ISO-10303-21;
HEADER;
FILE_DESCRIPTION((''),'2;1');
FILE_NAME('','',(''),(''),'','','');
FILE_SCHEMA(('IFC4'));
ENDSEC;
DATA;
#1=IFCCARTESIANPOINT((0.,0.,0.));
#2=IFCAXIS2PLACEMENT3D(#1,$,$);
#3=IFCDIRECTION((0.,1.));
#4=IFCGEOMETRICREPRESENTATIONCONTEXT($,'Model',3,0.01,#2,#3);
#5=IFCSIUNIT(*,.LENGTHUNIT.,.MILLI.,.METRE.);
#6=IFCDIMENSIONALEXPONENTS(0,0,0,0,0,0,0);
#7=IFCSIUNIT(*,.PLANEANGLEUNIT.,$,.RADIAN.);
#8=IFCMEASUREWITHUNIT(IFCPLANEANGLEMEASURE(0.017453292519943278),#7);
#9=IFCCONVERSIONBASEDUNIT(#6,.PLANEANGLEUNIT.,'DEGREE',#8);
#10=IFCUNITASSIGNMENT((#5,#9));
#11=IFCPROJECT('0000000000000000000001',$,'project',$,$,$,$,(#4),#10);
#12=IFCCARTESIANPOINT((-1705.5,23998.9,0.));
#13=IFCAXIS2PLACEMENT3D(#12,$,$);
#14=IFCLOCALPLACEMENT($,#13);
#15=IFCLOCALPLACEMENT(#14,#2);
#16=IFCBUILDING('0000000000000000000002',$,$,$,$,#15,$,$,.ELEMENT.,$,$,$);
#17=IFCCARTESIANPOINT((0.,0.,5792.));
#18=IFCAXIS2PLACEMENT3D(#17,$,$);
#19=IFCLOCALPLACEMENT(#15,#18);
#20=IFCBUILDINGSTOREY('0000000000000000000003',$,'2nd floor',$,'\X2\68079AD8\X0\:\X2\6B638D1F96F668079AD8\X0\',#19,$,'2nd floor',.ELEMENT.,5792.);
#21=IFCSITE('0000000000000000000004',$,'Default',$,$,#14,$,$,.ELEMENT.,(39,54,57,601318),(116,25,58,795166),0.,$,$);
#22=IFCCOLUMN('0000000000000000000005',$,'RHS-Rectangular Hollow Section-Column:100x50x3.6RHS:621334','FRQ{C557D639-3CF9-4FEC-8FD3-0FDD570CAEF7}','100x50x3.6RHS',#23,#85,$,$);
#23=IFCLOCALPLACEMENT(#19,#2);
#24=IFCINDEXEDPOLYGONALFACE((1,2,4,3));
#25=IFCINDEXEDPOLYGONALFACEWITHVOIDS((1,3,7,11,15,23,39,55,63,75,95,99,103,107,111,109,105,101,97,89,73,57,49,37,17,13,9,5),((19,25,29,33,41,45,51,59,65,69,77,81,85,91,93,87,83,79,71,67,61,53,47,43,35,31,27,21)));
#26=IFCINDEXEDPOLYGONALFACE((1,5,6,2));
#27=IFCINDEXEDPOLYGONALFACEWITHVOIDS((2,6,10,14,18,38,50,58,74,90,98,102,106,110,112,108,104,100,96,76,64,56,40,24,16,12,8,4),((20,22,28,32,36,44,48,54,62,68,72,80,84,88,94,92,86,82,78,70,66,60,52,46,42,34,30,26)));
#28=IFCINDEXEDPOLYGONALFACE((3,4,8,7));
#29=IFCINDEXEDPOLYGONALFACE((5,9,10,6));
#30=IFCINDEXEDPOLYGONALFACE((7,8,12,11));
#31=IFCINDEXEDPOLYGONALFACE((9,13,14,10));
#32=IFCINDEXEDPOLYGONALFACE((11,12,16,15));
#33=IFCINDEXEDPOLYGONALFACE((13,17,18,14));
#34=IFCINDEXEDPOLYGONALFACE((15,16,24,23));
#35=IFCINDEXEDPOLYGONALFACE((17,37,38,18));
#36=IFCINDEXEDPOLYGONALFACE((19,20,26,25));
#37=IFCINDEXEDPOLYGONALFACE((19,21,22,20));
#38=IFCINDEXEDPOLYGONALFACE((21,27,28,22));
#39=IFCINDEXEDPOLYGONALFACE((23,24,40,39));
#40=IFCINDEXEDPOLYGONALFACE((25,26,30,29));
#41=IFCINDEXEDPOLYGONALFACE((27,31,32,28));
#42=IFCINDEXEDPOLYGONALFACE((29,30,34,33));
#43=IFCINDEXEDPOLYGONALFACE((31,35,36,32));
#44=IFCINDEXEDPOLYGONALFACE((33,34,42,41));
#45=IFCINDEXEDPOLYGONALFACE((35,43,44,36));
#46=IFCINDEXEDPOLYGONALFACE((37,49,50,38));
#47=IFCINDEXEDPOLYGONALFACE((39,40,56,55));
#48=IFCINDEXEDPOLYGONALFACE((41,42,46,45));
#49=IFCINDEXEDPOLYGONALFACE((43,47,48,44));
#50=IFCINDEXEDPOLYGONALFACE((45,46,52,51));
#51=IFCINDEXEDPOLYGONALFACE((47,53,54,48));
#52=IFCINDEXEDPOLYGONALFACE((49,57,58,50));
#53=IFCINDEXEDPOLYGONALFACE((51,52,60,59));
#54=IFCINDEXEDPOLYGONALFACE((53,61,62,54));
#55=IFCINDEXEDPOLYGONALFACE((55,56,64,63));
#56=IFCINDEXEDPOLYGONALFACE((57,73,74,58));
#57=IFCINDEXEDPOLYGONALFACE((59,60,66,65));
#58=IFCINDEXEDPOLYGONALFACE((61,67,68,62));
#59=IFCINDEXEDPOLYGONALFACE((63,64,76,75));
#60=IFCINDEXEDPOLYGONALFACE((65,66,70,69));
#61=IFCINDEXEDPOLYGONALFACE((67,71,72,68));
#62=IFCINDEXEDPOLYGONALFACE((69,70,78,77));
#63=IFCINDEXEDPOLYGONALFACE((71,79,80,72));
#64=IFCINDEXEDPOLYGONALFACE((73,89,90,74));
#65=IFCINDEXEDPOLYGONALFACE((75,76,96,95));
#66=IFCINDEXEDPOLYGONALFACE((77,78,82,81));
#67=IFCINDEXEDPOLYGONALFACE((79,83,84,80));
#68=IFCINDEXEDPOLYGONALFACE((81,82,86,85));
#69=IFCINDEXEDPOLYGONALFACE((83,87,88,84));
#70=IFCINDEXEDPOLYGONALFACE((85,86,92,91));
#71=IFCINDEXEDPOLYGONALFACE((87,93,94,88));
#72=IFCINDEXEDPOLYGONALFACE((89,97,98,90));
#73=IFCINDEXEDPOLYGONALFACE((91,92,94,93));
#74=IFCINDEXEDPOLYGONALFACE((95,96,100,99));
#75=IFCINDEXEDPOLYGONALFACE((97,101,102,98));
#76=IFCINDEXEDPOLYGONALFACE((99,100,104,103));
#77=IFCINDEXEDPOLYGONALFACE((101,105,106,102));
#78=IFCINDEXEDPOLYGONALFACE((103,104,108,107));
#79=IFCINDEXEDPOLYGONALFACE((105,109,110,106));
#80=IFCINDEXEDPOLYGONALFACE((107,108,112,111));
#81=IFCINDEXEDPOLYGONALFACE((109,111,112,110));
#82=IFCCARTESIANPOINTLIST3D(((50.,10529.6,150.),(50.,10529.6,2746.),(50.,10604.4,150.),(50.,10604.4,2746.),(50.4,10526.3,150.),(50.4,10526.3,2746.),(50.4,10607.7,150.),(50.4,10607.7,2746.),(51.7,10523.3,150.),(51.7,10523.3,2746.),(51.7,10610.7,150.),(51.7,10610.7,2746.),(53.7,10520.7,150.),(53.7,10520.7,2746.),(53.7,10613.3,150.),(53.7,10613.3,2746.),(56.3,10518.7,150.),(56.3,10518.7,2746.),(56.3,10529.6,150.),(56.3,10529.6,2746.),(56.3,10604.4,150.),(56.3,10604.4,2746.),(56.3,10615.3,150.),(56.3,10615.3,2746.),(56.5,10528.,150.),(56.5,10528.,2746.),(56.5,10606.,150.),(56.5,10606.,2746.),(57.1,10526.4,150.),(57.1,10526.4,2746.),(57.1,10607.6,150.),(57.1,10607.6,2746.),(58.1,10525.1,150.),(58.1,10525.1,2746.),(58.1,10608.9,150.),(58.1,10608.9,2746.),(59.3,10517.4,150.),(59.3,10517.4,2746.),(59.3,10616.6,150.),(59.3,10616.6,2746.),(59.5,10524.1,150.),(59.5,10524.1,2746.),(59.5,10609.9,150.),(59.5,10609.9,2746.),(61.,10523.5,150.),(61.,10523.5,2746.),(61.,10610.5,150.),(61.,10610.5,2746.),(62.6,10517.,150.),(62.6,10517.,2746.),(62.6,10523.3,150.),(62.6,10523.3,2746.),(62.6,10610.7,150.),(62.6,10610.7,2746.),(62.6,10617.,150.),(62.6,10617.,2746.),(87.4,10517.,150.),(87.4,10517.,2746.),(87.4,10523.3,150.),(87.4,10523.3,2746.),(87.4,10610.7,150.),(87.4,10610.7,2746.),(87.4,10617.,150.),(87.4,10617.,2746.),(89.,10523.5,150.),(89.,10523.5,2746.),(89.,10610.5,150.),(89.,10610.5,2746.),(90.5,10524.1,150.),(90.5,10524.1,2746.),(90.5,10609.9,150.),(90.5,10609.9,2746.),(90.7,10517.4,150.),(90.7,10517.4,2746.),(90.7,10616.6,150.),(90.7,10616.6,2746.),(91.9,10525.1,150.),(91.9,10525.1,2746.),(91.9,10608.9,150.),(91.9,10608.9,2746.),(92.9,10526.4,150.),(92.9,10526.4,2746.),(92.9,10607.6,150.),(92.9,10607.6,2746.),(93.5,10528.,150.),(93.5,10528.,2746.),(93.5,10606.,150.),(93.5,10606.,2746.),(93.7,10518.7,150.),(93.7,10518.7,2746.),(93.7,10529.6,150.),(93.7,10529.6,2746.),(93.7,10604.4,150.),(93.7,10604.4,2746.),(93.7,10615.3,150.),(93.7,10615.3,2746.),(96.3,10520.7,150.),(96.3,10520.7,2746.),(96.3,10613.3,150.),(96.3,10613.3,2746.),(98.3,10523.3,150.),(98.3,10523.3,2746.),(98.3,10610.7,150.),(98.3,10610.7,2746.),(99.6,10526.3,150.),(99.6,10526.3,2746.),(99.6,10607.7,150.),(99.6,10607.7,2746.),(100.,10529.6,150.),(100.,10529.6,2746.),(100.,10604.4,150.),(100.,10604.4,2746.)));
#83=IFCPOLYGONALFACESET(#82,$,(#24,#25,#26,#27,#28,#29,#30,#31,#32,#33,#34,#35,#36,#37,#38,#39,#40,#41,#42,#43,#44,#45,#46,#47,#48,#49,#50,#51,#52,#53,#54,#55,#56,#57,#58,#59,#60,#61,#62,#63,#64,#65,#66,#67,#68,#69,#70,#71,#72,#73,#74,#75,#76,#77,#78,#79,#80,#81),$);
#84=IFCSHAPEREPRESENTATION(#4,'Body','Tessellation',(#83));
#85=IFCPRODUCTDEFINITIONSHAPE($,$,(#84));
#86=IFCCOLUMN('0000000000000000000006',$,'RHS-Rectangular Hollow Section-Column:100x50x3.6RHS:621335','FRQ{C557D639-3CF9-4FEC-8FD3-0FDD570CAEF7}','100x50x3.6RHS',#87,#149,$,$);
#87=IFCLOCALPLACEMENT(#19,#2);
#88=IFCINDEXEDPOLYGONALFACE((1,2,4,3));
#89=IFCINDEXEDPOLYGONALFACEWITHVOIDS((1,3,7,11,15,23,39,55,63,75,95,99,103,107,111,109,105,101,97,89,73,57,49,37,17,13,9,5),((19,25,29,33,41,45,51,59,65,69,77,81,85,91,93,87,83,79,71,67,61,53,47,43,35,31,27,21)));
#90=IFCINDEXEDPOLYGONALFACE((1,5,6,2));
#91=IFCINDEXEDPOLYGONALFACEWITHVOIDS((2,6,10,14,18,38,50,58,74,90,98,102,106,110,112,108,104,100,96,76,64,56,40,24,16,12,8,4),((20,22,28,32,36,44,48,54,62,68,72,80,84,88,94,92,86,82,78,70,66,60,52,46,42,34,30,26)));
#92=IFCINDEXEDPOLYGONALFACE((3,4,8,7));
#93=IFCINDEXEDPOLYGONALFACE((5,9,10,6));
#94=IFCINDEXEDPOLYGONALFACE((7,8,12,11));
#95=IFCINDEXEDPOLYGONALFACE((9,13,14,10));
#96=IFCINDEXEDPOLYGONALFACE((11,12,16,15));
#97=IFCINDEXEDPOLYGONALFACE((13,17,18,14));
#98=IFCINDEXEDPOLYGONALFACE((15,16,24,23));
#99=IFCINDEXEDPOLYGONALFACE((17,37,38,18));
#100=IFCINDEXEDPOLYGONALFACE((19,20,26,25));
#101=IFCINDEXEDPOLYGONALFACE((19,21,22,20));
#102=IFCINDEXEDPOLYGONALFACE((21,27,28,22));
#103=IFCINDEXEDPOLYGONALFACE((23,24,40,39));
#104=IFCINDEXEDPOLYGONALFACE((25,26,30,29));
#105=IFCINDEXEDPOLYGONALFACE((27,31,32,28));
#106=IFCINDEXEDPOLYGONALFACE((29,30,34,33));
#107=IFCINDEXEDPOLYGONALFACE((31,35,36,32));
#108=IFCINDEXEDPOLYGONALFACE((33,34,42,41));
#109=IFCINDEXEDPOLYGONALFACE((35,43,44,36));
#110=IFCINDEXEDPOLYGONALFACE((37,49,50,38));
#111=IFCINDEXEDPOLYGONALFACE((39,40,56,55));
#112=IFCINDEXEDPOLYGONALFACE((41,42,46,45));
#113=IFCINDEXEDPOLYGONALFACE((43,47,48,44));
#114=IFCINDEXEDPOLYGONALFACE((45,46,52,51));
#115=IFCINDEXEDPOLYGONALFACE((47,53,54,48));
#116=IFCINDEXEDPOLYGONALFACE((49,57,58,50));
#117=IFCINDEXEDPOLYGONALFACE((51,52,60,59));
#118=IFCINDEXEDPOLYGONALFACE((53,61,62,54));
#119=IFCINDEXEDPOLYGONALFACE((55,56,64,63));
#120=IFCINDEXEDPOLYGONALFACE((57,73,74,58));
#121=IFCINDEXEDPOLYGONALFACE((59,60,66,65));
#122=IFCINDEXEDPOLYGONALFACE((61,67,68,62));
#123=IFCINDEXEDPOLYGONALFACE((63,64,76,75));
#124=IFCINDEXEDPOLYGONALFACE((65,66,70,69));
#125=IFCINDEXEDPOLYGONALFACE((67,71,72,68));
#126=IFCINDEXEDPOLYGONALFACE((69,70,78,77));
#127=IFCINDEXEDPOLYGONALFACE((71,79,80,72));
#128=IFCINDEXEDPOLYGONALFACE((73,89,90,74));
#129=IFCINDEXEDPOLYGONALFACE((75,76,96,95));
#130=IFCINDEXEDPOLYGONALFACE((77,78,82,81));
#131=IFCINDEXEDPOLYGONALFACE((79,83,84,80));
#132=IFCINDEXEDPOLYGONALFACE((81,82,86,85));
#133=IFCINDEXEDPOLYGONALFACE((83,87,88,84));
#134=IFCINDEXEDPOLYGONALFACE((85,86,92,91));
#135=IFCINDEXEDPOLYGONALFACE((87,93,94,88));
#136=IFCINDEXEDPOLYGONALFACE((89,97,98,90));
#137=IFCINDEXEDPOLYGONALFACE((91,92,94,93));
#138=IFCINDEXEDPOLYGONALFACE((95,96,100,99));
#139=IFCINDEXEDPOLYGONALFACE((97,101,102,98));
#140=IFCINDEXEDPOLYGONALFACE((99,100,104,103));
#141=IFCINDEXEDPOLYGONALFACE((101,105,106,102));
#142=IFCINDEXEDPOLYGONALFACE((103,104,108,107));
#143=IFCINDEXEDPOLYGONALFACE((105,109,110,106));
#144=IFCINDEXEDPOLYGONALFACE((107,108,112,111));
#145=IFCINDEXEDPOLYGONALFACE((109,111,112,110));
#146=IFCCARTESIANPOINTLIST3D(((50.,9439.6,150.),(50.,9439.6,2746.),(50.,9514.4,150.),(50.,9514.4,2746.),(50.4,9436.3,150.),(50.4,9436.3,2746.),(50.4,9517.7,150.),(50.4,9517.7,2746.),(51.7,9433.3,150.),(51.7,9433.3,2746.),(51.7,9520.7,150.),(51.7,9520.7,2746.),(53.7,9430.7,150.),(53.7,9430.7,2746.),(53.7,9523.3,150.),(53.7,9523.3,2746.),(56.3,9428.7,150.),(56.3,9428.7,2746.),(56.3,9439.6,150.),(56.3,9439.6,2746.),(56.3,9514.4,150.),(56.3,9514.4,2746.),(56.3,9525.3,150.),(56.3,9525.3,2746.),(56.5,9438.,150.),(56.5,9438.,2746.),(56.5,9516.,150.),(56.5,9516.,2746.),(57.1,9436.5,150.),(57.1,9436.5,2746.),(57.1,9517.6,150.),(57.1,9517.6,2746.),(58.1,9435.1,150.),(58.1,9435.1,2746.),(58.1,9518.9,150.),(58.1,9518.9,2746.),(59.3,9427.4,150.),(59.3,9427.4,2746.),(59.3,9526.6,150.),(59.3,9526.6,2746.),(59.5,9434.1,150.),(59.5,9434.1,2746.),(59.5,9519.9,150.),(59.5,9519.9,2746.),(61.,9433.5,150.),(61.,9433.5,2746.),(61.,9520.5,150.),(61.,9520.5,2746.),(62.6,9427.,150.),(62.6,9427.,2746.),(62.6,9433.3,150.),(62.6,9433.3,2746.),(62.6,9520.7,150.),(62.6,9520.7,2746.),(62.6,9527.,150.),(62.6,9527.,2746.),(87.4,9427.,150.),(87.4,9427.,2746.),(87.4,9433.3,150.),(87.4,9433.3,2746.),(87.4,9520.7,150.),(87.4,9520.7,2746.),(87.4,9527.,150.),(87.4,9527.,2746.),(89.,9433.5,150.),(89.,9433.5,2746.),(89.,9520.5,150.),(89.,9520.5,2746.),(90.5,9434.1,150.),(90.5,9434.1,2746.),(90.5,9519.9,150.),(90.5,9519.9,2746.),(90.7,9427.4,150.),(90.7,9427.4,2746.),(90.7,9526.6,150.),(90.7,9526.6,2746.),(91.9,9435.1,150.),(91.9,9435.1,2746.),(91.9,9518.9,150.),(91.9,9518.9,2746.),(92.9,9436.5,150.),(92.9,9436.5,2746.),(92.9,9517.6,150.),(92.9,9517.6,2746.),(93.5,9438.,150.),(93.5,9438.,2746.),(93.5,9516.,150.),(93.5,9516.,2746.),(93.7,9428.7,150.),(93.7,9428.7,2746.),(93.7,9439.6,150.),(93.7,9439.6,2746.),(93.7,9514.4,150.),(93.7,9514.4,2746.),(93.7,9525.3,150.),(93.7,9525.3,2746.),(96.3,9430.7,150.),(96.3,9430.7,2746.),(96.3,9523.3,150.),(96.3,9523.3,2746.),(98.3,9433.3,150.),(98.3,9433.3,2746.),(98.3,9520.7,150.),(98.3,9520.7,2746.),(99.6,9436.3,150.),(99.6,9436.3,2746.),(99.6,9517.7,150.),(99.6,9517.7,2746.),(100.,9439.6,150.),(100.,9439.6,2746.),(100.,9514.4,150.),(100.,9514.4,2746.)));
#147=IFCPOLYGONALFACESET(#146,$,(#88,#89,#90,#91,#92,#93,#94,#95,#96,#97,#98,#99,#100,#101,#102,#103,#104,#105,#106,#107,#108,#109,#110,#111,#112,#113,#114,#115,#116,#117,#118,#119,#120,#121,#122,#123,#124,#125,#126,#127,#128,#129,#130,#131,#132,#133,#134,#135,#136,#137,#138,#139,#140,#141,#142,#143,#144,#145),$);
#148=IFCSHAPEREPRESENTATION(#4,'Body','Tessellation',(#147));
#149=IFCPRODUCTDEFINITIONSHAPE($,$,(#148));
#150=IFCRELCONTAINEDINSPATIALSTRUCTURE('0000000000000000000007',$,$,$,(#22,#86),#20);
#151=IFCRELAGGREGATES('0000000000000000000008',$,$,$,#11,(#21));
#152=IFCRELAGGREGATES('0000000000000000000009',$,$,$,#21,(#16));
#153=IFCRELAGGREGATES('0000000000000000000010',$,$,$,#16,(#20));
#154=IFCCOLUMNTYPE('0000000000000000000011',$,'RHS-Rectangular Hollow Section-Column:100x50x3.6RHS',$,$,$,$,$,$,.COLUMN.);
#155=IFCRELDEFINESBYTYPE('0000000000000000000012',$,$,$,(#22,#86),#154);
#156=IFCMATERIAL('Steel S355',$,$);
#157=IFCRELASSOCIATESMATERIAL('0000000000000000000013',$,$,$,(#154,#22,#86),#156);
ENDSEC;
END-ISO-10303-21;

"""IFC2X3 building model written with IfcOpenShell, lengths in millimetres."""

from ifc_helpers import new_model, entity, si_unit, converted_unit, direction, frame, origin, origin_2d, place, context, project, spatial, hollow_rectangle, extrude, clip, halfspace, material, type_object, element, save


model = new_model("IFC2X3")

# Units and contexts
model_context = context("Model", 3, precision=0.01, world=origin(), true_north=direction((0.0, 1.0)))
ifc_project = project(units=[si_unit("LENGTHUNIT", "METRE", prefix="MILLI"), converted_unit("PLANEANGLEUNIT", "DEGREE", entity("IfcPlaneAngleMeasure", 0.017453292519943278), si_unit("PLANEANGLEUNIT", "RADIAN"), dimensions=[0, 0, 0, 0, 0, 0, 0])], contexts=[model_context])

# Site, building, storey
site_placement = place(None, frame((-1705.5, 23998.9, 0.0)))
site = spatial("IfcSite", under=ifc_project, at=site_placement, Name="Default", CompositionType="ELEMENT", RefLatitude=(39, 54, 57, 601318), RefLongitude=(116, 25, 58, 795166), RefElevation=0.0)
building_placement = place(site_placement, origin())
building = spatial("IfcBuilding", under=site, at=building_placement, CompositionType="ELEMENT")
storey_placement = place(building_placement, frame((0.0, 0.0, 5792.0)))
storey = spatial("IfcBuildingStorey", under=building, at=storey_placement, Name="2nd floor", ObjectType="标高:正负零标高", LongName="2nd floor", CompositionType="ELEMENT", Elevation=5792.0)

# Columns
ifc_material_1 = material(Name="Steel S355")
column_type_1 = type_object("IfcColumnType", Name="RHS-Rectangular Hollow Section-Column:100x50x3.6RHS", PredefinedType="COLUMN", material=ifc_material_1)
column_1_placement = place(storey_placement, frame((75.0, 10567.0, 2746.0), z_axis=(0.0, 0.0, 1.0), x_axis=(-1.0, 0.0, 0.0)))
element("IfcColumn", 1, at=column_1_placement, inside=storey, type_object=column_type_1, material=ifc_material_1, Name="RHS-Rectangular Hollow Section-Column:100x50x3.6RHS:621334", Description="FRQ{C557D639-3CF9-4FEC-8FD3-0FDD570CAEF7}", ObjectType="100x50x3.6RHS", context=model_context, shape_type="Clipping", body=[
    clip(extrude(hollow_rectangle(XDim=50.0, YDim=100.0, WallThickness=6.3, InnerFilletRadius=6.3, OuterFilletRadius=12.6, at=origin_2d()), origin(), (0.0, 0.0, -1.0), 2651.9), halfspace(frame((75.0, 10567.0, -2596.0), z_axis=(0.0, 0.0, 1.0), x_axis=(-1.0, 0.0, 0.0)), True)),
])
column_2_placement = place(storey_placement, frame((75.0, 9477.0, 2746.0), z_axis=(0.0, 0.0, 1.0), x_axis=(-1.0, 0.0, 0.0)))
element("IfcColumn", 2, at=column_2_placement, inside=storey, type_object=column_type_1, material=ifc_material_1, Name="RHS-Rectangular Hollow Section-Column:100x50x3.6RHS:621335", Description="FRQ{C557D639-3CF9-4FEC-8FD3-0FDD570CAEF7}", ObjectType="100x50x3.6RHS", context=model_context, shape_type="Clipping", body=[
    clip(extrude(hollow_rectangle(XDim=50.0, YDim=100.0, WallThickness=6.3, InnerFilletRadius=6.3, OuterFilletRadius=12.6, at=origin_2d()), origin(), (0.0, 0.0, -1.0), 2651.9), halfspace(frame((75.0, 9477.0, -2596.0), z_axis=(0.0, 0.0, 1.0), x_axis=(-1.0, 0.0, 0.0)), True)),
])

save(model, "model.ifc")
